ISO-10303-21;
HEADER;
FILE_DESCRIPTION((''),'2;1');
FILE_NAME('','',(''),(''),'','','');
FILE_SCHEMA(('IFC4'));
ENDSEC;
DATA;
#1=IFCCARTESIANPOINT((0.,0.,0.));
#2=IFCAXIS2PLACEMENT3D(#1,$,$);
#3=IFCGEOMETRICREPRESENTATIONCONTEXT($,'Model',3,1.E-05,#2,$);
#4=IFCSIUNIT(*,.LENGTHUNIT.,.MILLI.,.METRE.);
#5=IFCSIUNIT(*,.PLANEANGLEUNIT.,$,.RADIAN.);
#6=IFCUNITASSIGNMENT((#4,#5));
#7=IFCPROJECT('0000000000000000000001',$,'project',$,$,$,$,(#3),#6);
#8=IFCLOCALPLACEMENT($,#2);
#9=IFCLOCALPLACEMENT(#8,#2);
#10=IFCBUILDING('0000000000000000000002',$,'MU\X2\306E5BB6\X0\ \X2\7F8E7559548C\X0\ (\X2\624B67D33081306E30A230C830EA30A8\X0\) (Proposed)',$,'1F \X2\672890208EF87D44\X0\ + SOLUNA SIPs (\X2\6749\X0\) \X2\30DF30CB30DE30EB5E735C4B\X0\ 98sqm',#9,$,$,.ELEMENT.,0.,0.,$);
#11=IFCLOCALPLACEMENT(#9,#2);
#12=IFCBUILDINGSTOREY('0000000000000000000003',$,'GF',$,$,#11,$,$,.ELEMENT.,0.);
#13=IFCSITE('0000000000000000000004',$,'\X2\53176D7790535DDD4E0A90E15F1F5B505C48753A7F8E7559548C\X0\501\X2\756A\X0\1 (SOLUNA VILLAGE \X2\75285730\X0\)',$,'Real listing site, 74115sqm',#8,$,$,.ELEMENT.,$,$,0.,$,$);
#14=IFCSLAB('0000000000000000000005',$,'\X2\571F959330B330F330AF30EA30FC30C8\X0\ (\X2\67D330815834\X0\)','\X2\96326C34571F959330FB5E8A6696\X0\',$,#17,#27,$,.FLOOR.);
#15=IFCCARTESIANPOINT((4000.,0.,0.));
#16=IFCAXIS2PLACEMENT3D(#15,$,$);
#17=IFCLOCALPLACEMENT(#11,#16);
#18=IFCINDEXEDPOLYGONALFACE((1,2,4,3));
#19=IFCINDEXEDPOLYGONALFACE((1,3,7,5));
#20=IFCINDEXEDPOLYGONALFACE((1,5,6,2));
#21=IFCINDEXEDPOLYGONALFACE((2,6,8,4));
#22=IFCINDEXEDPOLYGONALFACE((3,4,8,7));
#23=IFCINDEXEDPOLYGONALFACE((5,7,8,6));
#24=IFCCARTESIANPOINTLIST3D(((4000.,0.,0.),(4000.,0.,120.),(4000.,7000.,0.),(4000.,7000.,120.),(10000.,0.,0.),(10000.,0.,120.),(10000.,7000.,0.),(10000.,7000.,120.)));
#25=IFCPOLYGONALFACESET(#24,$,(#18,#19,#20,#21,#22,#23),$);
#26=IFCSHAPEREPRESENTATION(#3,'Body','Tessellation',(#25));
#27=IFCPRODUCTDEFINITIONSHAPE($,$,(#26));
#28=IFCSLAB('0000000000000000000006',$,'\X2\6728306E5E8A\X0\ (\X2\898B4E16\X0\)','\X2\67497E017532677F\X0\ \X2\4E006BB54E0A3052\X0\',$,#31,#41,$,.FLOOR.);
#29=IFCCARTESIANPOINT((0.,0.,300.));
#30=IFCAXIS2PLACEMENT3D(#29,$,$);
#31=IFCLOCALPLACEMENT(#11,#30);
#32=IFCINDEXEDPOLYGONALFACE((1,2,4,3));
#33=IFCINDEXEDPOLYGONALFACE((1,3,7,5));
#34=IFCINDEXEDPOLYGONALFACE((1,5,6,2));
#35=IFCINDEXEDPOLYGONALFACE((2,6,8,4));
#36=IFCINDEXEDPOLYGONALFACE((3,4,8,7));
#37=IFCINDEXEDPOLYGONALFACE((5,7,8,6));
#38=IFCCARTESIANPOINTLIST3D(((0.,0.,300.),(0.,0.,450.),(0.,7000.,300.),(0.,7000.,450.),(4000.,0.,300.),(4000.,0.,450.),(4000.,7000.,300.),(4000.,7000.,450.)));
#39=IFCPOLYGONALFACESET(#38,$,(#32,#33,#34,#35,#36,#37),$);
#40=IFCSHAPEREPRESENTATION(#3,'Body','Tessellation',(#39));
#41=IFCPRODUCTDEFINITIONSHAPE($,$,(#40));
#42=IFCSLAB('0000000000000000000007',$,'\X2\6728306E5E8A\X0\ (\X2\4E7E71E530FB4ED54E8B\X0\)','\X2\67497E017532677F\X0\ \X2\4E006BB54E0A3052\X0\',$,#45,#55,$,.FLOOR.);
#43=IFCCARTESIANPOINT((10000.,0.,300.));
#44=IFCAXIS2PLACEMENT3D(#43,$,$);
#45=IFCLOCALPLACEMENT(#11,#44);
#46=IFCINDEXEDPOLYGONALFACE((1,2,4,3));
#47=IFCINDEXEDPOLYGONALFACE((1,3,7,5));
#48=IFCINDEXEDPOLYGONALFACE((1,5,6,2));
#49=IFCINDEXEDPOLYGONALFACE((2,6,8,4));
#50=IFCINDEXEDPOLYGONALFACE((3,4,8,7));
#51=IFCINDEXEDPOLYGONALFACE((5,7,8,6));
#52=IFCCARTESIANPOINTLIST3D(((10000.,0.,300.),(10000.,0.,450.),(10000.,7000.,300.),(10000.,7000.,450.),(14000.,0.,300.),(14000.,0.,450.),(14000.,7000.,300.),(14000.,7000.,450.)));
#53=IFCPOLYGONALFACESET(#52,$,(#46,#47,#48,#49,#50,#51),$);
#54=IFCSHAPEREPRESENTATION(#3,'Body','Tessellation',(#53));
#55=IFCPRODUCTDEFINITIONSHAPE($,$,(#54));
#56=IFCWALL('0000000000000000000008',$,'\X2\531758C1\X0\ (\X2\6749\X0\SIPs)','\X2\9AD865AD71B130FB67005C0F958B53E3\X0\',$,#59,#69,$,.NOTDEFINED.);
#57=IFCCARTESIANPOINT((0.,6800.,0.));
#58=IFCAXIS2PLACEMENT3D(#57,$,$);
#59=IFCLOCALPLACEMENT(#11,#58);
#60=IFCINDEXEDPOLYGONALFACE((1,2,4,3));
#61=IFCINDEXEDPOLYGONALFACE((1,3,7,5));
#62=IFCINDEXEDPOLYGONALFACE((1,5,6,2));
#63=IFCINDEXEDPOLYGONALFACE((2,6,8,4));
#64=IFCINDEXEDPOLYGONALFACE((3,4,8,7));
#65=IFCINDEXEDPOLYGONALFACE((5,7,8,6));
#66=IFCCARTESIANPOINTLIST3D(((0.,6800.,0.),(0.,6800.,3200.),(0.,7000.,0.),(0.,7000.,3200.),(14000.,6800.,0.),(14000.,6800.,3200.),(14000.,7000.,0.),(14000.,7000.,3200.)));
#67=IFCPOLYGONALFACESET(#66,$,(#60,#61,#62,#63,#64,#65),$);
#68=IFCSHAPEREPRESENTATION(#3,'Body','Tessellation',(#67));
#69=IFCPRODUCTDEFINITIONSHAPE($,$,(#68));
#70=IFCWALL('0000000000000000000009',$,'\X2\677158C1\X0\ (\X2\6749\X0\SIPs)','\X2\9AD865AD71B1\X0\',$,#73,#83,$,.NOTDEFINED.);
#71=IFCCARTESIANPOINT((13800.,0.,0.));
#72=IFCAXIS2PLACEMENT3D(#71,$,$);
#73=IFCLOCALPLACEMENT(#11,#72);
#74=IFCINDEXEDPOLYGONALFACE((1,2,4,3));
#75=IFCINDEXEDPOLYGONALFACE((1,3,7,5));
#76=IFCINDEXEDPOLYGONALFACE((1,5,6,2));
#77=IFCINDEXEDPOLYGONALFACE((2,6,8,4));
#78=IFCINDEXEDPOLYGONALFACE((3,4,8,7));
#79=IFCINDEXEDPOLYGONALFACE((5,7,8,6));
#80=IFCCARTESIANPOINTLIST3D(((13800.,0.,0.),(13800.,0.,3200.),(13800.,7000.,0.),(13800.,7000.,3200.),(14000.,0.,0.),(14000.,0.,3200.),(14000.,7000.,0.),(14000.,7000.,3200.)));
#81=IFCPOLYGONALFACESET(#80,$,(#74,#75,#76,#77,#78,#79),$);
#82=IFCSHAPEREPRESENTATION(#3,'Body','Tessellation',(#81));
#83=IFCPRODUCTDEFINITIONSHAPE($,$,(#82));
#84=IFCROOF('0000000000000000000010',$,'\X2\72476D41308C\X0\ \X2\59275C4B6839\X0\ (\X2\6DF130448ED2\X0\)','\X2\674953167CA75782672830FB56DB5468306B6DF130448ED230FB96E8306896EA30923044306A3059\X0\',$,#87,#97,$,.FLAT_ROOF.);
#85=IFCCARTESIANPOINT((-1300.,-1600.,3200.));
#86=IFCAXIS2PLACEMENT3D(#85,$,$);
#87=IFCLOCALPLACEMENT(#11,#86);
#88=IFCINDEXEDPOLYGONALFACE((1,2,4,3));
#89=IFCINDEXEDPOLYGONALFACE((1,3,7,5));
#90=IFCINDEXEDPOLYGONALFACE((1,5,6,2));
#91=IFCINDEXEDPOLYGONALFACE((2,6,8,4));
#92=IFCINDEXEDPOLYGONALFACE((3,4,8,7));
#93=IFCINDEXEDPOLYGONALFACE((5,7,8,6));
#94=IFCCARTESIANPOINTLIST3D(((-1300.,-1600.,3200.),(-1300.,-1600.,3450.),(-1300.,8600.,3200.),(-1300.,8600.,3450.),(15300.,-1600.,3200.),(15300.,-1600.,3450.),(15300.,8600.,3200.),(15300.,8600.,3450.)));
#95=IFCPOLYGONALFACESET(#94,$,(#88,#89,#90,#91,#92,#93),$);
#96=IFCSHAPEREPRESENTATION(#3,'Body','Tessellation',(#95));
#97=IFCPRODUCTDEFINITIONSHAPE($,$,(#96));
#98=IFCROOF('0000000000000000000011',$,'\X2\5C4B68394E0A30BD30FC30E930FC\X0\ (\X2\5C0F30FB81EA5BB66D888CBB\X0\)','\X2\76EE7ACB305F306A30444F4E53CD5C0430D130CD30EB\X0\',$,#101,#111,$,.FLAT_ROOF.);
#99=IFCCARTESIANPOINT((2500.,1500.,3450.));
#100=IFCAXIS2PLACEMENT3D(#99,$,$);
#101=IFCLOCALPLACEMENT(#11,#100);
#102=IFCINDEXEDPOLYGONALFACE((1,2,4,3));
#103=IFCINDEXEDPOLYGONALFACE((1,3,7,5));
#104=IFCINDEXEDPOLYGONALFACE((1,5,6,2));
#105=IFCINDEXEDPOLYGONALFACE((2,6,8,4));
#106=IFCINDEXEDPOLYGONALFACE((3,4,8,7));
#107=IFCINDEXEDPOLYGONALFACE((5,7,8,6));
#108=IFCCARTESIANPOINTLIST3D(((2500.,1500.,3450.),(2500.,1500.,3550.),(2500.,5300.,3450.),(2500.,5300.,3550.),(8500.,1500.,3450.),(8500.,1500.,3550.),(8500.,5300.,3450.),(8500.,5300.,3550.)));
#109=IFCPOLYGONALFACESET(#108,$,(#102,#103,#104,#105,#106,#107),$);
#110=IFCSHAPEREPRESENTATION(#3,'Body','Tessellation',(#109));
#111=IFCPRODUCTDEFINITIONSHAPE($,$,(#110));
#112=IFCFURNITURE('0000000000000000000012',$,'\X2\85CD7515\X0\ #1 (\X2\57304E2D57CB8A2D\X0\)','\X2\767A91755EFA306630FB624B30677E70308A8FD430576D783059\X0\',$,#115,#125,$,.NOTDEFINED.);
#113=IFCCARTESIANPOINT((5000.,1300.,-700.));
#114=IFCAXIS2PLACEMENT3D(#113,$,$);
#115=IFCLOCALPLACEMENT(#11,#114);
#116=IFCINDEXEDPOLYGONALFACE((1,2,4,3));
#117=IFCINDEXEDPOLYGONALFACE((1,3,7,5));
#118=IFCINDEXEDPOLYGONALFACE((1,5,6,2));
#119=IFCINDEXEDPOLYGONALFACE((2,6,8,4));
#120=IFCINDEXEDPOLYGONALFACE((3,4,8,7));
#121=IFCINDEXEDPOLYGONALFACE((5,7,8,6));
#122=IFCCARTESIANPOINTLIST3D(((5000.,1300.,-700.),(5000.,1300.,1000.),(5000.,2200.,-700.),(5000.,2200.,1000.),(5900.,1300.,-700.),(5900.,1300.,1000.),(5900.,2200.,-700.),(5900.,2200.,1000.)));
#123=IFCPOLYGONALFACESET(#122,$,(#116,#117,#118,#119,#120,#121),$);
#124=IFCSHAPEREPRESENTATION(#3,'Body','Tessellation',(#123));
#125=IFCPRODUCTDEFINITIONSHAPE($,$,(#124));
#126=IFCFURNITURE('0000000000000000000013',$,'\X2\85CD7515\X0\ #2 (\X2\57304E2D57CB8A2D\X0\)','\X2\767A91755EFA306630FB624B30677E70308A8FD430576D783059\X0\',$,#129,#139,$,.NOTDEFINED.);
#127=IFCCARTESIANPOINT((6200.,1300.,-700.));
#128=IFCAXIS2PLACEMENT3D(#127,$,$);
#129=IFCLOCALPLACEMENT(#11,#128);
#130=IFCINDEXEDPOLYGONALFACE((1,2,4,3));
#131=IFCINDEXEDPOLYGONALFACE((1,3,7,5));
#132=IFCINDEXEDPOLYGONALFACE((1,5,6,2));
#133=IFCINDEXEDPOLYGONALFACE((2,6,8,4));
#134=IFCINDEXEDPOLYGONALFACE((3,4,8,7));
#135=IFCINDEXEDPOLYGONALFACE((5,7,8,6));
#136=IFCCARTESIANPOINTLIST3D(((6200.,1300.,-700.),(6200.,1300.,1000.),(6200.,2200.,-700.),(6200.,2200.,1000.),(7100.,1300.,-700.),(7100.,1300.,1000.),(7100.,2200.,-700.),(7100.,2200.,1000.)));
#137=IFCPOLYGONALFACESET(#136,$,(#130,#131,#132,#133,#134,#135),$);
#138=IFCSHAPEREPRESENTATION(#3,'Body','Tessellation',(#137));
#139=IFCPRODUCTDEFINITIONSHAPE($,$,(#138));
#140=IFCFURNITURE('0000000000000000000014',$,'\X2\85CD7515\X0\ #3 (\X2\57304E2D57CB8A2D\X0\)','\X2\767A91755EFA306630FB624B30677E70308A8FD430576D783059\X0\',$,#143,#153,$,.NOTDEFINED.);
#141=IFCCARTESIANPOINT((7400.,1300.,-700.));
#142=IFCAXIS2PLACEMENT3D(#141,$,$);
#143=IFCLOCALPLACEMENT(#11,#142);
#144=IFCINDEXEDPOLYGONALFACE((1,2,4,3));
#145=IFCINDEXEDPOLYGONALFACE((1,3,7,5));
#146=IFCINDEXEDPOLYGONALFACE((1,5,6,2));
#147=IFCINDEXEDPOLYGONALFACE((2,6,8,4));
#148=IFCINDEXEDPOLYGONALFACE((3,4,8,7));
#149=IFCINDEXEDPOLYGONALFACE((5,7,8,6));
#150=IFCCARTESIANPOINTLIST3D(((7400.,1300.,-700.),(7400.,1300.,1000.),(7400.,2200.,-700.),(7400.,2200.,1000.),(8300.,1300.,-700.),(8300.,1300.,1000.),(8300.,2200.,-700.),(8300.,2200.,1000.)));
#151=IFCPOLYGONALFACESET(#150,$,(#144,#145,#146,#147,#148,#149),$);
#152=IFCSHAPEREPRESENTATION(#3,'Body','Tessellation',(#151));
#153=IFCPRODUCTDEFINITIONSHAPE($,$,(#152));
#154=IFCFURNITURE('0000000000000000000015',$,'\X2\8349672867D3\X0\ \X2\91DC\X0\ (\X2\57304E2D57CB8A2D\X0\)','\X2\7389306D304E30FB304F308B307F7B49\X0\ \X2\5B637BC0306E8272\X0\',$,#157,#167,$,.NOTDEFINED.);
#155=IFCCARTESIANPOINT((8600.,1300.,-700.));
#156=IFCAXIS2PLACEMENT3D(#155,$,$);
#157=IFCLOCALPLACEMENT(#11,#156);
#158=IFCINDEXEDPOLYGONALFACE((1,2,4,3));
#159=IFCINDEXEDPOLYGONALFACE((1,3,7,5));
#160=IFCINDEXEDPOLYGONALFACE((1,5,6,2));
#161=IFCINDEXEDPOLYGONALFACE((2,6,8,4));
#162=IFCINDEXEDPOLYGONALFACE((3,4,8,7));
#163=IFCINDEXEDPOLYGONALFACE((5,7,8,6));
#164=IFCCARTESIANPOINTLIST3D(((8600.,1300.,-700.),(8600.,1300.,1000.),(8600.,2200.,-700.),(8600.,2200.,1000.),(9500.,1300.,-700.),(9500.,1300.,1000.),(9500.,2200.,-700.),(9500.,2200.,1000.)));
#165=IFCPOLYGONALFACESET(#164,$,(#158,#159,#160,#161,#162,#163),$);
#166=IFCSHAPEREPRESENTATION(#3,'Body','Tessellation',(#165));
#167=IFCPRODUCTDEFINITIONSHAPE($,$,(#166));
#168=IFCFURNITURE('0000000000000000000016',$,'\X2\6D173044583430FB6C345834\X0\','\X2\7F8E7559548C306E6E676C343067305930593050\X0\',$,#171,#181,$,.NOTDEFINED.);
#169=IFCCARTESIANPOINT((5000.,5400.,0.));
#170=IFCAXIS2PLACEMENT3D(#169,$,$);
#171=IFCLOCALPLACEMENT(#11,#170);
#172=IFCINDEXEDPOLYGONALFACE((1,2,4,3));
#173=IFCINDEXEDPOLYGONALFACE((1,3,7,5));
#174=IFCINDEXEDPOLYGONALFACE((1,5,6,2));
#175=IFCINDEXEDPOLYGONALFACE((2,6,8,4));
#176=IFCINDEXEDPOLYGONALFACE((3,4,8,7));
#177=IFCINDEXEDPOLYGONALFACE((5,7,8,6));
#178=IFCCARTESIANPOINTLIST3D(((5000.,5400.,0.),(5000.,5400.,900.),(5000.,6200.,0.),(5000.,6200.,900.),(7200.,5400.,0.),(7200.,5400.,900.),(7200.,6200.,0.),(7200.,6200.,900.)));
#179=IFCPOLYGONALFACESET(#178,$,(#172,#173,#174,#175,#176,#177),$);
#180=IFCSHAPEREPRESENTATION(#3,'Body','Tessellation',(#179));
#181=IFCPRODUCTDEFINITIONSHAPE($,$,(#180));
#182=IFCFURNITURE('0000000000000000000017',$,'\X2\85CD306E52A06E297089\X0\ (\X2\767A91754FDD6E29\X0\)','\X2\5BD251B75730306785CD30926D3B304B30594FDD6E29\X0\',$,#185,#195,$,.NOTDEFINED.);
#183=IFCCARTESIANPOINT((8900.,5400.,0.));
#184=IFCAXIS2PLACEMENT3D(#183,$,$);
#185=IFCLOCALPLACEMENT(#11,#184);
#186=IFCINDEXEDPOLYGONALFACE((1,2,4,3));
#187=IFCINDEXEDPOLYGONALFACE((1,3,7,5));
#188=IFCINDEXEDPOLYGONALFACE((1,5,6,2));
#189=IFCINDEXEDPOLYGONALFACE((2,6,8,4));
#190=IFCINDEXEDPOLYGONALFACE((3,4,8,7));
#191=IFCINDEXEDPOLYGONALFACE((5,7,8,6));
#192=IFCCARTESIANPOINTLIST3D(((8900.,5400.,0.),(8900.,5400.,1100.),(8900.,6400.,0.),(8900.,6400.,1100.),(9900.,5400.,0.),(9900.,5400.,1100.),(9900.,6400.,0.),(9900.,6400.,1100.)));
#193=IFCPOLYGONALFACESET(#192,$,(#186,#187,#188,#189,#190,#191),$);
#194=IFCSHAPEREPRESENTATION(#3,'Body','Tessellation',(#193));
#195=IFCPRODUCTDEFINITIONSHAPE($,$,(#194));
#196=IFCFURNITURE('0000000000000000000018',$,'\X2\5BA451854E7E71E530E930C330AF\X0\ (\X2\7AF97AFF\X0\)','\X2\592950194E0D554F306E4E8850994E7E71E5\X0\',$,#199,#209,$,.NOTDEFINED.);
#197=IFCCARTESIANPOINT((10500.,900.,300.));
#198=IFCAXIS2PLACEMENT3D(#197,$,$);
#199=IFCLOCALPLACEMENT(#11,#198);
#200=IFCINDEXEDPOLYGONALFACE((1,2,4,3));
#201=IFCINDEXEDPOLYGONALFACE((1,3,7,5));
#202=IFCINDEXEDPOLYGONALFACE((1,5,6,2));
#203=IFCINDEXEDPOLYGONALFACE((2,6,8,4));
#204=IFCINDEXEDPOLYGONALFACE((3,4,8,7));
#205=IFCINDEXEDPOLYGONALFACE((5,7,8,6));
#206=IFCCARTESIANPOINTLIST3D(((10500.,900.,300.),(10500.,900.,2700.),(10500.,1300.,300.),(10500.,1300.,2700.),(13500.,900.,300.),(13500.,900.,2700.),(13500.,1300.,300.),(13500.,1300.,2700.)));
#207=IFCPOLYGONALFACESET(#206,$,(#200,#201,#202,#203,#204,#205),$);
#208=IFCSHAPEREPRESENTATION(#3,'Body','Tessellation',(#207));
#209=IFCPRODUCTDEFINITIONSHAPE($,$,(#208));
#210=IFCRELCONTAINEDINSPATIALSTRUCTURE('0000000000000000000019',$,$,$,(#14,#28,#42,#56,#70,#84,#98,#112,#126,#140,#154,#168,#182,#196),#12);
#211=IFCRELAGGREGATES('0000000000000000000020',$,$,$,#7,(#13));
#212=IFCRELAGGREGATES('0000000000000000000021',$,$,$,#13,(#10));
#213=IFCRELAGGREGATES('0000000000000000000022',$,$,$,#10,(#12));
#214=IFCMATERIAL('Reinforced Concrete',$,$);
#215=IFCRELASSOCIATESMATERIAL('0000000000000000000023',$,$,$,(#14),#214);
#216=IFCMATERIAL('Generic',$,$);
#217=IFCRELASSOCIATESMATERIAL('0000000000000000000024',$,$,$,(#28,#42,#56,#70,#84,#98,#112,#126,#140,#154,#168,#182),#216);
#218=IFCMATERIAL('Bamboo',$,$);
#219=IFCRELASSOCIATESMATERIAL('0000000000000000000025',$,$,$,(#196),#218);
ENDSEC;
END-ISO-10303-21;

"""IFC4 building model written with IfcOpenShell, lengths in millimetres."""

from ifc_helpers import new_model, si_unit, frame, frame_2d, origin, place, context, project, spatial, rectangle, extrude, material, element, save


model = new_model("IFC4")

# Units and contexts
model_context = context("Model", 3, precision=1e-05, world=origin())
ifc_project = project(units=[si_unit("LENGTHUNIT", "METRE", prefix="MILLI"), si_unit("PLANEANGLEUNIT", "RADIAN")], contexts=[model_context])

# Site, building, storey
site_placement = place(None, origin())
site = spatial("IfcSite", under=ifc_project, at=site_placement, Name="北海道川上郡弟子屈町美留和501番1 (SOLUNA VILLAGE 用地)", ObjectType="Real listing site, 74115sqm", CompositionType="ELEMENT", RefElevation=0.0)
building_placement = place(site_placement, origin())
building = spatial("IfcBuilding", under=site, at=building_placement, Name="MUの家 美留和 (手染めのアトリエ) (Proposed)", ObjectType="1F 木造軸組 + SOLUNA SIPs (杉) ミニマル平屋 98sqm", CompositionType="ELEMENT", ElevationOfRefHeight=0.0, ElevationOfTerrain=0.0)
storey_placement = place(building_placement, origin())
storey = spatial("IfcBuildingStorey", under=building, at=storey_placement, Name="GF", CompositionType="ELEMENT", Elevation=0.0)

# Slabs
ifc_material_1 = material(Name="Generic")
ifc_material_2 = material(Name="Reinforced Concrete")
slab_1_placement = place(storey_placement, frame((4000.0, 0.0, 0.0)))
element("IfcSlab", 1, at=slab_1_placement, inside=storey, material=ifc_material_2, Name="土間コンクリート (染め場)", Description="防水土間・床暖", PredefinedType="FLOOR", context=model_context, shape_type="SweptSolid", body=[
    extrude(rectangle(XDim=6000.0, YDim=7000.0, at=frame_2d((3000.0, 3500.0))), frame((4000.0, 0.0, 0.0)), (0.0, 0.0, 1.0), 120.0),
])
slab_2_placement = place(storey_placement, frame((0.0, 0.0, 300.0)))
element("IfcSlab", 2, at=slab_2_placement, inside=storey, material=ifc_material_1, Name="木の床 (見世)", Description="杉縁甲板 一段上げ", PredefinedType="FLOOR", context=model_context, shape_type="SweptSolid", body=[
    extrude(rectangle(XDim=4000.0, YDim=7000.0, at=frame_2d((2000.0, 3500.0))), frame((0.0, 0.0, 300.0)), (0.0, 0.0, 1.0), 150.0),
])
slab_3_placement = place(storey_placement, frame((10000.0, 0.0, 300.0)))
element("IfcSlab", 3, at=slab_3_placement, inside=storey, material=ifc_material_1, Name="木の床 (乾燥・仕事)", Description="杉縁甲板 一段上げ", PredefinedType="FLOOR", context=model_context, shape_type="SweptSolid", body=[
    extrude(rectangle(XDim=4000.0, YDim=7000.0, at=frame_2d((2000.0, 3500.0))), frame((10000.0, 0.0, 300.0)), (0.0, 0.0, 1.0), 150.0),
])

# Walls
wall_1_placement = place(storey_placement, frame((0.0, 6800.0, 0.0)))
element("IfcWall", 4, at=wall_1_placement, inside=storey, material=ifc_material_1, Name="北壁 (杉SIPs)", Description="高断熱・最小開口", PredefinedType="NOTDEFINED", context=model_context, shape_type="SweptSolid", body=[
    extrude(rectangle(XDim=14000.0, YDim=200.0, at=frame_2d((7000.0, 100.0))), frame((0.0, 6800.0, 0.0)), (0.0, 0.0, 1.0), 3200.0),
])
wall_2_placement = place(storey_placement, frame((13800.0, 0.0, 0.0)))
element("IfcWall", 5, at=wall_2_placement, inside=storey, material=ifc_material_1, Name="東壁 (杉SIPs)", Description="高断熱", PredefinedType="NOTDEFINED", context=model_context, shape_type="SweptSolid", body=[
    extrude(rectangle(XDim=200.0, YDim=7000.0, at=frame_2d((100.0, 3500.0))), frame((13800.0, 0.0, 0.0)), (0.0, 0.0, 1.0), 3200.0),
])

# Roofs
roof_1_placement = place(storey_placement, frame((-1300.0, -1600.0, 3200.0)))
element("IfcRoof", 6, at=roof_1_placement, inside=storey, material=ifc_material_1, Name="片流れ 大屋根 (深い軒)", Description="杉化粧垂木・四周に深い軒・雨と雪をいなす", PredefinedType="FLAT_ROOF", context=model_context, shape_type="SweptSolid", body=[
    extrude(rectangle(XDim=16600.0, YDim=10200.0, at=frame_2d((8300.0, 5100.0))), frame((-1300.0, -1600.0, 3200.0)), (0.0, 0.0, 1.0), 250.0),
])
roof_2_placement = place(storey_placement, frame((2500.0, 1500.0, 3450.0)))
element("IfcRoof", 7, at=roof_2_placement, inside=storey, material=ifc_material_1, Name="屋根上ソーラー (小・自家消費)", Description="目立たない低反射パネル", PredefinedType="FLAT_ROOF", context=model_context, shape_type="SweptSolid", body=[
    extrude(rectangle(XDim=6000.0, YDim=3800.0, at=frame_2d((3000.0, 1900.0))), frame((2500.0, 1500.0, 3450.0)), (0.0, 0.0, 1.0), 100.0),
])

# Furniture
furniture_1_placement = place(storey_placement, frame((5000.0, 1300.0, -700.0)))
element("IfcFurniture", 8, at=furniture_1_placement, inside=storey, material=ifc_material_1, Name="藍甕 #1 (地中埋設)", Description="発酵建て・手で繰り返し浸す", PredefinedType="NOTDEFINED", context=model_context, shape_type="SweptSolid", body=[
    extrude(rectangle(XDim=900.0, YDim=900.0, at=frame_2d((450.0, 450.0))), frame((5000.0, 1300.0, -700.0)), (0.0, 0.0, 1.0), 1700.0),
])
furniture_2_placement = place(storey_placement, frame((6200.0, 1300.0, -700.0)))
element("IfcFurniture", 9, at=furniture_2_placement, inside=storey, material=ifc_material_1, Name="藍甕 #2 (地中埋設)", Description="発酵建て・手で繰り返し浸す", PredefinedType="NOTDEFINED", context=model_context, shape_type="SweptSolid", body=[
    extrude(rectangle(XDim=900.0, YDim=900.0, at=frame_2d((450.0, 450.0))), frame((6200.0, 1300.0, -700.0)), (0.0, 0.0, 1.0), 1700.0),
])
furniture_3_placement = place(storey_placement, frame((7400.0, 1300.0, -700.0)))
element("IfcFurniture", 10, at=furniture_3_placement, inside=storey, material=ifc_material_1, Name="藍甕 #3 (地中埋設)", Description="発酵建て・手で繰り返し浸す", PredefinedType="NOTDEFINED", context=model_context, shape_type="SweptSolid", body=[
    extrude(rectangle(XDim=900.0, YDim=900.0, at=frame_2d((450.0, 450.0))), frame((7400.0, 1300.0, -700.0)), (0.0, 0.0, 1.0), 1700.0),
])
furniture_4_placement = place(storey_placement, frame((8600.0, 1300.0, -700.0)))
element("IfcFurniture", 11, at=furniture_4_placement, inside=storey, material=ifc_material_1, Name="草木染 釜 (地中埋設)", Description="玉ねぎ・くるみ等 季節の色", PredefinedType="NOTDEFINED", context=model_context, shape_type="SweptSolid", body=[
    extrude(rectangle(XDim=900.0, YDim=900.0, at=frame_2d((450.0, 450.0))), frame((8600.0, 1300.0, -700.0)), (0.0, 0.0, 1.0), 1700.0),
])
furniture_5_placement = place(storey_placement, frame((5000.0, 5400.0, 0.0)))
element("IfcFurniture", 12, at=furniture_5_placement, inside=storey, material=ifc_material_1, Name="洗い場・水場", Description="美留和の湧水ですすぐ", PredefinedType="NOTDEFINED", context=model_context, shape_type="SweptSolid", body=[
    extrude(rectangle(XDim=2200.0, YDim=800.0, at=frame_2d((1100.0, 400.0))), frame((5000.0, 5400.0, 0.0)), (0.0, 0.0, 1.0), 900.0),
])
furniture_6_placement = place(storey_placement, frame((8900.0, 5400.0, 0.0)))
element("IfcFurniture", 13, at=furniture_6_placement, inside=storey, material=ifc_material_1, Name="藍の加温炉 (発酵保温)", Description="寒冷地で藍を活かす保温", PredefinedType="NOTDEFINED", context=model_context, shape_type="SweptSolid", body=[
    extrude(rectangle(XDim=1000.0, YDim=1000.0, at=frame_2d((500.0, 500.0))), frame((8900.0, 5400.0, 0.0)), (0.0, 0.0, 1.0), 1100.0),
])
ifc_material_3 = material(Name="Bamboo")
furniture_7_placement = place(storey_placement, frame((10500.0, 900.0, 300.0)))
element("IfcFurniture", 14, at=furniture_7_placement, inside=storey, material=ifc_material_3, Name="室内乾燥ラック (竹竿)", Description="天候不問の予備乾燥", PredefinedType="NOTDEFINED", context=model_context, shape_type="SweptSolid", body=[
    extrude(rectangle(XDim=3000.0, YDim=400.0, at=frame_2d((1500.0, 200.0))), frame((10500.0, 900.0, 300.0)), (0.0, 0.0, 1.0), 2400.0),
])

save(model, "model.ifc")
